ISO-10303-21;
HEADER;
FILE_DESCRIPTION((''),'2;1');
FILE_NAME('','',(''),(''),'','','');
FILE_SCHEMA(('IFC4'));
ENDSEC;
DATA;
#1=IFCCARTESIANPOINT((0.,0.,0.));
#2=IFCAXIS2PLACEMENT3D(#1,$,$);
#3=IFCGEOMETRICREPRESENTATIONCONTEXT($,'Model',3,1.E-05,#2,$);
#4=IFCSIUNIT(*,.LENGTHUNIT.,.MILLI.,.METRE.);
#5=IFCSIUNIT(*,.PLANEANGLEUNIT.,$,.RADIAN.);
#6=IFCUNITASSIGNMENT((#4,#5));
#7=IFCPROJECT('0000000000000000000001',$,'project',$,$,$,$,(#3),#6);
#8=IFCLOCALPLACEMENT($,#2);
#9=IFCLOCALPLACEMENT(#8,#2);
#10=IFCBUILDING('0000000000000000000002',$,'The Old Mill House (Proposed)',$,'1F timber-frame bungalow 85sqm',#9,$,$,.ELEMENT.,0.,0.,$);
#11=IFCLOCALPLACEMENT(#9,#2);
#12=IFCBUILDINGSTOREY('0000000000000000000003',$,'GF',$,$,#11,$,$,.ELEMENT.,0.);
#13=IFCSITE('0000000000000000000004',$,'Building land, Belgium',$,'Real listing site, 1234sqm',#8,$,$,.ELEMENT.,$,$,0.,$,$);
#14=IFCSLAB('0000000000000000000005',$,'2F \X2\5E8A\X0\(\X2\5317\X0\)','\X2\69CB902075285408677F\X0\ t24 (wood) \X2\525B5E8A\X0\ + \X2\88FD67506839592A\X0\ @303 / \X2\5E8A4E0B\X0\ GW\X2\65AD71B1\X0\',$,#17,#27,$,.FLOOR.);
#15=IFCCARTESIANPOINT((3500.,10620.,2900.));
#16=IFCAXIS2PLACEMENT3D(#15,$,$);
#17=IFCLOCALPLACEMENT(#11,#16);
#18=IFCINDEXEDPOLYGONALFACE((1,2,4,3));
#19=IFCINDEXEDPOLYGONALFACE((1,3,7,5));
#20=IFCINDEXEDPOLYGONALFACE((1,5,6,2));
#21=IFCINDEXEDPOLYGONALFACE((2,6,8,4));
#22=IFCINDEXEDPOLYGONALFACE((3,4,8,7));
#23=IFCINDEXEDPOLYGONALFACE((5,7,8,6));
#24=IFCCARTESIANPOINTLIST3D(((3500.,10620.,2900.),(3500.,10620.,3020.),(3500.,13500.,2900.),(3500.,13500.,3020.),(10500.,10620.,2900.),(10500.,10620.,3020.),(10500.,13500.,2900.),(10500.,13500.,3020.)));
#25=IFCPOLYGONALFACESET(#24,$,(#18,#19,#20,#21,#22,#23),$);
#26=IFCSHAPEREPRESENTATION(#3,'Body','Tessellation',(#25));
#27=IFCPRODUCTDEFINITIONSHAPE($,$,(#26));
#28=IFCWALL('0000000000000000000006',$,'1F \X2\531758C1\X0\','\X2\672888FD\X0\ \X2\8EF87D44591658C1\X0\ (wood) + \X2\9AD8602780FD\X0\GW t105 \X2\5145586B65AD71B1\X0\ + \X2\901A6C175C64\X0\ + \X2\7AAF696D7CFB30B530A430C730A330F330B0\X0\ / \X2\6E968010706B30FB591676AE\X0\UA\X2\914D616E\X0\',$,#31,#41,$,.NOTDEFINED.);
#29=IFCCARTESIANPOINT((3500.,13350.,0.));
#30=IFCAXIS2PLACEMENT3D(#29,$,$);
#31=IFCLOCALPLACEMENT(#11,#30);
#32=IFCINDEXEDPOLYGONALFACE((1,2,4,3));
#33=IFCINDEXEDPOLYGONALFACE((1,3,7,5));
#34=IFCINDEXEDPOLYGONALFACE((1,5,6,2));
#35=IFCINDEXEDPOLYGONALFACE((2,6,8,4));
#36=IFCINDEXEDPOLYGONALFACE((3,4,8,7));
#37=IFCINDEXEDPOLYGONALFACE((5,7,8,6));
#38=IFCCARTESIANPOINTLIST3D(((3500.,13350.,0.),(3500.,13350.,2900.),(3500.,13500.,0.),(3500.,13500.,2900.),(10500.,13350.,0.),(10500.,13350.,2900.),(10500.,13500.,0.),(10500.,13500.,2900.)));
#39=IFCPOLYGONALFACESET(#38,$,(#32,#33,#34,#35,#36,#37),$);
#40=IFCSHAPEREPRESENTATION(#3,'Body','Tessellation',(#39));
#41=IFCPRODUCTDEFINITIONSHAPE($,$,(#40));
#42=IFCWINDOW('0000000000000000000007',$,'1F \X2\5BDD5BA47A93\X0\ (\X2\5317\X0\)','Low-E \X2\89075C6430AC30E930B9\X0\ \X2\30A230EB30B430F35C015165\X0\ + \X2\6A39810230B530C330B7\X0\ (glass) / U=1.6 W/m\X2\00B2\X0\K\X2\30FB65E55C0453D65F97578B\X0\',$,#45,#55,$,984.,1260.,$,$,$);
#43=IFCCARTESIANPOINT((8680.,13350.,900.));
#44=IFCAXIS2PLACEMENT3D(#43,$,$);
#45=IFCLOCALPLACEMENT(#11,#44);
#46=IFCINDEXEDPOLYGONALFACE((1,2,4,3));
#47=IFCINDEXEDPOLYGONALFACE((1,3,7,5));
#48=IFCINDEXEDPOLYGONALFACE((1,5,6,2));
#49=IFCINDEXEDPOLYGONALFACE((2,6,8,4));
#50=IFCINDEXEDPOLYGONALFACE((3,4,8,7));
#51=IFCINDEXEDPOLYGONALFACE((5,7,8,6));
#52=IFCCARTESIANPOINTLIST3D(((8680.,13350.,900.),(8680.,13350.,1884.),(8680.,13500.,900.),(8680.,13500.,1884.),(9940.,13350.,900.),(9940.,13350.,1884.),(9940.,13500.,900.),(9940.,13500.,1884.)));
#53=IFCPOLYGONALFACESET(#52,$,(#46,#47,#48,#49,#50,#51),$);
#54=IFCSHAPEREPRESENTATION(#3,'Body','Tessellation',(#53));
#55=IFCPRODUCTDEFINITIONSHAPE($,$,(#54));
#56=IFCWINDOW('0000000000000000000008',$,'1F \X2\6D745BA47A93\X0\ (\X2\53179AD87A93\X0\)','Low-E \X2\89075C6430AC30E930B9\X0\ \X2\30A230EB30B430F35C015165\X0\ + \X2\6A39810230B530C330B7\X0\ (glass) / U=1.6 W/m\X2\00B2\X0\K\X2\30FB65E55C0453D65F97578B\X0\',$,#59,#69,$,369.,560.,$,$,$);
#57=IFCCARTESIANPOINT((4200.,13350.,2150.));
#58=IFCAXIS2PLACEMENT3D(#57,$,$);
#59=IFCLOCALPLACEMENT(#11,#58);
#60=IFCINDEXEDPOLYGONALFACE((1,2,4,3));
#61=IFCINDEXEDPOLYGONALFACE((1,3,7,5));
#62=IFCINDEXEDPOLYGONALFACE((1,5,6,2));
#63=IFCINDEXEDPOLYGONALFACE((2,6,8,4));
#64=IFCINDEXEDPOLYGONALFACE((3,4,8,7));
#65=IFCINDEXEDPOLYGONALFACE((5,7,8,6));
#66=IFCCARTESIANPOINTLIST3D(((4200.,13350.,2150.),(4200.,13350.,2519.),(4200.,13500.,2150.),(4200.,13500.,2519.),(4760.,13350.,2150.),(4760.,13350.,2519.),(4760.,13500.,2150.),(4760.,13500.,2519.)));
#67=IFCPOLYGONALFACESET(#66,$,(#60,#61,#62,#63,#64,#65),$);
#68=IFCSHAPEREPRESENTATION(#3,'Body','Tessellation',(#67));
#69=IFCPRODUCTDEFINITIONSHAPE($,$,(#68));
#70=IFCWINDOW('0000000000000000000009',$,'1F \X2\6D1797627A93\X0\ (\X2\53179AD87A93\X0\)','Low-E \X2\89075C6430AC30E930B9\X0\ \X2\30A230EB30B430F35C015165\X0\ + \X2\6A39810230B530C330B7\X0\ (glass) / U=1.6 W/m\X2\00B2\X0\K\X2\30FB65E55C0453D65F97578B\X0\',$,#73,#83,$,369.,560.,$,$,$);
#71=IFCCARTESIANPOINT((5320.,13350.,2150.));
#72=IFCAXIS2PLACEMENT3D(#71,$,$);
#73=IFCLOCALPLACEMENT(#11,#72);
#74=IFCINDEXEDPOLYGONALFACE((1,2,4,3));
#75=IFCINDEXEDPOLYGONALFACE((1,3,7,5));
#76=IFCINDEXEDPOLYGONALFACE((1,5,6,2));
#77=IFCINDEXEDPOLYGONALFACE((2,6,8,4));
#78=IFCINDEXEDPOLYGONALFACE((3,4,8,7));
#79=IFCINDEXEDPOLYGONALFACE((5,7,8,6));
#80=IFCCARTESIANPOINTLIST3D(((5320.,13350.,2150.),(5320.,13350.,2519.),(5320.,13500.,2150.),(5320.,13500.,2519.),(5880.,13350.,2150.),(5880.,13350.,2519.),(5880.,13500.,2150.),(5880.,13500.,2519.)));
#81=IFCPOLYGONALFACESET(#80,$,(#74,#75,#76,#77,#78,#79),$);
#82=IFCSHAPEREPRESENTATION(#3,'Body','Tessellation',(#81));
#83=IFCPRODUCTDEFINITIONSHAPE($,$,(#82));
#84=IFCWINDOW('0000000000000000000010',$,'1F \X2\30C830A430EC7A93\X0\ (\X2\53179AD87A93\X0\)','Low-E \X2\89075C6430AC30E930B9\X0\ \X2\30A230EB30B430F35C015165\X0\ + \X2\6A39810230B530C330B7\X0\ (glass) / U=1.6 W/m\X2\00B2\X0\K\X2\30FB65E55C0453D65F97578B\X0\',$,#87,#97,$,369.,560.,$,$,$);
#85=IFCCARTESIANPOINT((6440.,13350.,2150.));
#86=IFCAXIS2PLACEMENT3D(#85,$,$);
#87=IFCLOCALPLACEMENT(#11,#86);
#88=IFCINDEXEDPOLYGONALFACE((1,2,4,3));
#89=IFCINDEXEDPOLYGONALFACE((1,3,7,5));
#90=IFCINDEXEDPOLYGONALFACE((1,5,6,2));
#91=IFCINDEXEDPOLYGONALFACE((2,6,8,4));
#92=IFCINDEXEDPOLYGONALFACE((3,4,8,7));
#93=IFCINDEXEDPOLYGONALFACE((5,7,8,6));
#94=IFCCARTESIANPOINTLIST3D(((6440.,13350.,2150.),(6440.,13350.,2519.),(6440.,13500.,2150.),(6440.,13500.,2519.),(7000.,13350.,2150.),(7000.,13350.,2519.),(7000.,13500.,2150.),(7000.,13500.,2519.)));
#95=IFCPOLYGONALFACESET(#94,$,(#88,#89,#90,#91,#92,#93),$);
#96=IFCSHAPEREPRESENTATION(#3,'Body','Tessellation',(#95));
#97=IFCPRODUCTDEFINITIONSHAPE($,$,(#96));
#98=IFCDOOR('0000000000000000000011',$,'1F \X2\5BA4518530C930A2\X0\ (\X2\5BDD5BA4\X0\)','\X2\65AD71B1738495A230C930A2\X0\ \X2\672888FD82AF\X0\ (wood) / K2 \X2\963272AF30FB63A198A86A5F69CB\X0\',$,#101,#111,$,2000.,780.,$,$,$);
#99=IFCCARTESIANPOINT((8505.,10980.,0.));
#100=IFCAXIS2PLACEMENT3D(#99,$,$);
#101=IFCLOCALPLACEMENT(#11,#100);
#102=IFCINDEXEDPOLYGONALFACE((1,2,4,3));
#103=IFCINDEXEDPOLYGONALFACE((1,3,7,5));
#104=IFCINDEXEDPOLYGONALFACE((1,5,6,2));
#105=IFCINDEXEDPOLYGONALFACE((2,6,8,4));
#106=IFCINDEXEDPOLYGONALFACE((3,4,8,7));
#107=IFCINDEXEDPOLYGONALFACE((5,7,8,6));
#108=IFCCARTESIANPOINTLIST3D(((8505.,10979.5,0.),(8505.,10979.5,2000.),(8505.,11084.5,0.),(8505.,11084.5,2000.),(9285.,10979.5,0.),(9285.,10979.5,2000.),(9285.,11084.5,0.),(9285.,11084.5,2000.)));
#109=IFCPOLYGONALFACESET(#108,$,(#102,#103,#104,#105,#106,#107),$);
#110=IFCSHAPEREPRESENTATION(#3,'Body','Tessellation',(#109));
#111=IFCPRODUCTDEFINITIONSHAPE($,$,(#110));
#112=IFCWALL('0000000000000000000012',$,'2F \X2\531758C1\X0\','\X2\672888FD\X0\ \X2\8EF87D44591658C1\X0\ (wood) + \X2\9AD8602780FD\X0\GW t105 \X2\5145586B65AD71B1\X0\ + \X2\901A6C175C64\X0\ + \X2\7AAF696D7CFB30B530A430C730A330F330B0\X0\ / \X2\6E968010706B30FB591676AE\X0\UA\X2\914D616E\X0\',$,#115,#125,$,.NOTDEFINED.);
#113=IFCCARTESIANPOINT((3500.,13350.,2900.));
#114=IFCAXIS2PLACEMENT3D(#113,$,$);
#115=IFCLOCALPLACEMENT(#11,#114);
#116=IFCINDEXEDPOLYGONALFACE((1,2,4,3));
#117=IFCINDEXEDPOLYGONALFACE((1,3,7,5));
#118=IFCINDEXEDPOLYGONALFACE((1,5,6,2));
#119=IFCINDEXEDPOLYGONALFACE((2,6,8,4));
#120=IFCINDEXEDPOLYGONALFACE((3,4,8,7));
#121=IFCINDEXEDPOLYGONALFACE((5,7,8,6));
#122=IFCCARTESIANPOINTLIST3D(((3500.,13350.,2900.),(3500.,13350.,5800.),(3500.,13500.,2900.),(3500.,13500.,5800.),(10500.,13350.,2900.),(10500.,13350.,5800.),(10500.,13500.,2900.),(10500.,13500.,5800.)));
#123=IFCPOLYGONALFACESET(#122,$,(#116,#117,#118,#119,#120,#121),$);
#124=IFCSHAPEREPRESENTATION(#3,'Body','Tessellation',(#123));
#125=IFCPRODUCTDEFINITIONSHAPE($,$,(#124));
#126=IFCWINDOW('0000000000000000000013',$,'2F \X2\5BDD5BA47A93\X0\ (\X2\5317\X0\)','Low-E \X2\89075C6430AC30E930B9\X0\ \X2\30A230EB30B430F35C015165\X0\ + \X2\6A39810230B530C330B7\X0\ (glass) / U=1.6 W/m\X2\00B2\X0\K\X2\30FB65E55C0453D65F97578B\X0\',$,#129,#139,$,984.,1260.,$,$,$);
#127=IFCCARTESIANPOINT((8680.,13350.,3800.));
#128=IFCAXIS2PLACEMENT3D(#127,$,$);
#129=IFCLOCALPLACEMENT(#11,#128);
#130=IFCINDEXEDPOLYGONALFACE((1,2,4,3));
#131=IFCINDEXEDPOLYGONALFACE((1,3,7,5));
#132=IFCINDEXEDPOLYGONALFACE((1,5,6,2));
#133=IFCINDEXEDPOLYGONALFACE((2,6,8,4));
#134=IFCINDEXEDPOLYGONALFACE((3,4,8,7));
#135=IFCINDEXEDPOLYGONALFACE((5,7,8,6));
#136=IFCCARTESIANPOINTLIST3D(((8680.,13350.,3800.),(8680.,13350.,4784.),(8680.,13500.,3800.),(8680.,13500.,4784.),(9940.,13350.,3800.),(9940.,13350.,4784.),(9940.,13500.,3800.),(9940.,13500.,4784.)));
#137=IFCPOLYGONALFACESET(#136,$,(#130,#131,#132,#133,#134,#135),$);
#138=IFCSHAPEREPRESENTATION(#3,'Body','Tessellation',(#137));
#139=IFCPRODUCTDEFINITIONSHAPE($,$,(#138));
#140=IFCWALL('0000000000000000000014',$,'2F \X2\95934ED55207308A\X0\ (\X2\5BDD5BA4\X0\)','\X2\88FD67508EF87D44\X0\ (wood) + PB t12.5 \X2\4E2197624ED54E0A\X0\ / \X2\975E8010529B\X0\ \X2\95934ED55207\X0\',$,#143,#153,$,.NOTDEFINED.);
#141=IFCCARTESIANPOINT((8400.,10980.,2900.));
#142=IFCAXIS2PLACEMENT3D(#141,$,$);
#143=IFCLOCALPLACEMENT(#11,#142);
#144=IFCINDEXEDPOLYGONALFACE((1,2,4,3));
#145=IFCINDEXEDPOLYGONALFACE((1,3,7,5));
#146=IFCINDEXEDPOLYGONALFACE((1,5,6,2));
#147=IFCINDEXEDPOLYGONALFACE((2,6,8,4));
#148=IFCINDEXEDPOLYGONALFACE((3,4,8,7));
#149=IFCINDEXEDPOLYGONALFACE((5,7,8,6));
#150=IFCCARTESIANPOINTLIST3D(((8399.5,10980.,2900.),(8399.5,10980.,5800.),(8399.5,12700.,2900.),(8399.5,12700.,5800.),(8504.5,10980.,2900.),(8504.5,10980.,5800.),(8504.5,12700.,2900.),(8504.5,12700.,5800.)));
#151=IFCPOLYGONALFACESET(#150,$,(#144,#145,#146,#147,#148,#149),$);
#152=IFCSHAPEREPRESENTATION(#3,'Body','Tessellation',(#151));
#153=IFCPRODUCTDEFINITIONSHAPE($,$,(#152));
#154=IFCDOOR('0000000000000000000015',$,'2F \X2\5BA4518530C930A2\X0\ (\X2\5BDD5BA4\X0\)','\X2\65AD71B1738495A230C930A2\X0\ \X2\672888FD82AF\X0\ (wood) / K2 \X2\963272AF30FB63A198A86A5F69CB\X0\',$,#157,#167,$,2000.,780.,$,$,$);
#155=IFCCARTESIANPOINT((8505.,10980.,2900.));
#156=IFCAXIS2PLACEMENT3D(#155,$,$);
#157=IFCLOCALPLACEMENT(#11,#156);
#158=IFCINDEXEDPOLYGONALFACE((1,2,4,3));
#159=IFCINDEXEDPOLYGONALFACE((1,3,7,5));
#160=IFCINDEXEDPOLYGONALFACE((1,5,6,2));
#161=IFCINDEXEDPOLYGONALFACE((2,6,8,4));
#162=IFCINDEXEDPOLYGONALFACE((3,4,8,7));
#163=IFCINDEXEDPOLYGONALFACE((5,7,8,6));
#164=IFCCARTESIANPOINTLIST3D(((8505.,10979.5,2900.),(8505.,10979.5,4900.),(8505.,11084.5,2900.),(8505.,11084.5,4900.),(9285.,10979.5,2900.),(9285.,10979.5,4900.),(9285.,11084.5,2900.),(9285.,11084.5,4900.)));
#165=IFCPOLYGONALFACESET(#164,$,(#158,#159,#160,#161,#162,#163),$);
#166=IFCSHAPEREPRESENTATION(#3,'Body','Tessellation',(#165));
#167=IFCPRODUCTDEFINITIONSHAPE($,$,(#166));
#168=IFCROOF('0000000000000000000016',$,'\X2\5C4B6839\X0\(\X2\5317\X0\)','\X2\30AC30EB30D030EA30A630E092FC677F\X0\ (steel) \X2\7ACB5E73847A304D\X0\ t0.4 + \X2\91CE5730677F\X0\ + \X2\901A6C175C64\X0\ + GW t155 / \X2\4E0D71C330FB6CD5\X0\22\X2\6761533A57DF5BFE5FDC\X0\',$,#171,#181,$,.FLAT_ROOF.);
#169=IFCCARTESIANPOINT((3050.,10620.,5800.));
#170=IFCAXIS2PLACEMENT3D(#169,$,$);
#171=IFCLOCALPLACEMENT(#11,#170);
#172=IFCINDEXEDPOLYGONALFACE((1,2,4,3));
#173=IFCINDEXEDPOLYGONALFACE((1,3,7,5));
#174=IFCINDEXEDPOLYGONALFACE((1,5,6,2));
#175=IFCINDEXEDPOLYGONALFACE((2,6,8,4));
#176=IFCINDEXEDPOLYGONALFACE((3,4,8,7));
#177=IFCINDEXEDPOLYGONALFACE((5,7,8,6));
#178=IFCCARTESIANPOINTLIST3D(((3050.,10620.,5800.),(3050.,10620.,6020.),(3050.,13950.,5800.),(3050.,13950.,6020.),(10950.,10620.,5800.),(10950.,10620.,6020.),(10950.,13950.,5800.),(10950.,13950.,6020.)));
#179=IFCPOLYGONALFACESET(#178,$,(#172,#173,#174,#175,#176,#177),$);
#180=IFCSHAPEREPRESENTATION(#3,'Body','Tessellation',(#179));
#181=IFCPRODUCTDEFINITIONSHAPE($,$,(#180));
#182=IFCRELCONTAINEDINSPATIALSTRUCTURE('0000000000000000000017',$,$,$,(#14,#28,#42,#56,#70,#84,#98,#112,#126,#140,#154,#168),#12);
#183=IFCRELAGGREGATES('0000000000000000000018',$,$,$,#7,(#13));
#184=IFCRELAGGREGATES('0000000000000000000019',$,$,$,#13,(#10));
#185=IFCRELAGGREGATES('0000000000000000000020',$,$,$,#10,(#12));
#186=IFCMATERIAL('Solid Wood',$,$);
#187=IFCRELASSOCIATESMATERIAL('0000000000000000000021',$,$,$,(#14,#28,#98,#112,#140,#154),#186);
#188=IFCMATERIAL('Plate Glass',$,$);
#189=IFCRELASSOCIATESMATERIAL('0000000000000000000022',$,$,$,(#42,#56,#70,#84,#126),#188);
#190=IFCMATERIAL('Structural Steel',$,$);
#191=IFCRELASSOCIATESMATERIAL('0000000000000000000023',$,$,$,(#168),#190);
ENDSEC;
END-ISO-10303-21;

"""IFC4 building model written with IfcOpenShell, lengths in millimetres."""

from ifc_helpers import new_model, si_unit, frame, frame_2d, origin, place, context, project, spatial, rectangle, extrude, material, element, fill, save


model = new_model("IFC4")

# Units and contexts
model_context = context("Model", 3, precision=1e-05, world=origin())
ifc_project = project(units=[si_unit("LENGTHUNIT", "METRE", prefix="MILLI"), si_unit("PLANEANGLEUNIT", "RADIAN")], contexts=[model_context])

# Site, building, storey
site_placement = place(None, origin())
site = spatial("IfcSite", under=ifc_project, at=site_placement, Name="Building land, Belgium", ObjectType="Real listing site, 1234sqm", CompositionType="ELEMENT", RefElevation=0.0)
building_placement = place(site_placement, origin())
building = spatial("IfcBuilding", under=site, at=building_placement, Name="The Old Mill House (Proposed)", ObjectType="1F timber-frame bungalow 85sqm", CompositionType="ELEMENT", ElevationOfRefHeight=0.0, ElevationOfTerrain=0.0)
storey_placement = place(building_placement, origin())
storey = spatial("IfcBuildingStorey", under=building, at=storey_placement, Name="GF", CompositionType="ELEMENT", Elevation=0.0)

# Slab
ifc_material_1 = material(Name="Solid Wood")
slab_placement = place(storey_placement, frame((3500.0, 10620.0, 2900.0)))
element("IfcSlab", 1, at=slab_placement, inside=storey, material=ifc_material_1, Name="2F 床(北)", Description="構造用合板 t24 (wood) 剛床 + 製材根太 @303 / 床下 GW断熱", PredefinedType="FLOOR", context=model_context, shape_type="SweptSolid", body=[
    extrude(rectangle(XDim=7000.0, YDim=2880.0, at=frame_2d((3500.0, 1440.0))), frame((3500.0, 10620.0, 2900.0)), (0.0, 0.0, 1.0), 120.0),
])

# Wall, openings, windows
wall_1_placement = place(storey_placement, frame((3500.0, 13350.0, 0.0)))
wall_1 = element("IfcWall", 2, at=wall_1_placement, inside=storey, material=ifc_material_1, Name="1F 北壁", Description="木製 軸組外壁 (wood) + 高性能GW t105 充填断熱 + 通気層 + 窯業系サイディング / 準耐火・外皮UA配慮", PredefinedType="NOTDEFINED", context=model_context, shape_type="SweptSolid", body=[
    extrude(rectangle(XDim=7000.0, YDim=150.0, at=frame_2d((3500.0, 75.0))), frame((3500.0, 13350.0, 0.0)), (0.0, 0.0, 1.0), 2900.0),
])
opening_1_placement = place(storey_placement, frame((8680.0, 13350.0, 900.0)))
opening_1 = element("IfcOpeningElement", 3, at=opening_1_placement, cuts=wall_1, PredefinedType="NOTDEFINED", context=model_context, shape_type="SweptSolid", body=[
    extrude(rectangle(XDim=1260.0, YDim=150.0, at=frame_2d((630.0, 75.0))), frame((8680.0, 13350.0, 900.0)), (0.0, 0.0, 1.0), 984.0),
])
opening_2_placement = place(storey_placement, frame((4200.0, 13350.0, 2150.0)))
opening_2 = element("IfcOpeningElement", 4, at=opening_2_placement, cuts=wall_1, PredefinedType="NOTDEFINED", context=model_context, shape_type="SweptSolid", body=[
    extrude(rectangle(XDim=560.0, YDim=150.0, at=frame_2d((280.0, 75.0))), frame((4200.0, 13350.0, 2150.0)), (0.0, 0.0, 1.0), 369.0),
])
opening_3_placement = place(storey_placement, frame((5320.0, 13350.0, 2150.0)))
opening_3 = element("IfcOpeningElement", 5, at=opening_3_placement, cuts=wall_1, PredefinedType="NOTDEFINED", context=model_context, shape_type="SweptSolid", body=[
    extrude(rectangle(XDim=560.0, YDim=150.0, at=frame_2d((280.0, 75.0))), frame((5320.0, 13350.0, 2150.0)), (0.0, 0.0, 1.0), 369.0),
])
opening_4_placement = place(storey_placement, frame((6440.0, 13350.0, 2150.0)))
opening_4 = element("IfcOpeningElement", 6, at=opening_4_placement, cuts=wall_1, PredefinedType="NOTDEFINED", context=model_context, shape_type="SweptSolid", body=[
    extrude(rectangle(XDim=560.0, YDim=150.0, at=frame_2d((280.0, 75.0))), frame((6440.0, 13350.0, 2150.0)), (0.0, 0.0, 1.0), 369.0),
])
ifc_material_2 = material(Name="Plate Glass")
window_1_placement = place(storey_placement, frame((8680.0, 13350.0, 900.0)))
window_1 = element("IfcWindow", 7, at=window_1_placement, inside=storey, material=ifc_material_2, Name="1F 寝室窓 (北)", Description="Low-E 複層ガラス アルゴン封入 + 樹脂サッシ (glass) / U=1.6 W/m²K・日射取得型", OverallHeight=984.0, OverallWidth=1260.0, context=model_context, shape_type="SweptSolid", body=[
    extrude(rectangle(XDim=1260.0, YDim=150.0, at=frame_2d((630.0, 75.0))), frame((8680.0, 13350.0, 900.0)), (0.0, 0.0, 1.0), 984.0),
])
fill(opening_1, window_1)
window_2_placement = place(storey_placement, frame((4200.0, 13350.0, 2150.0)))
window_2 = element("IfcWindow", 8, at=window_2_placement, inside=storey, material=ifc_material_2, Name="1F 浴室窓 (北高窓)", Description="Low-E 複層ガラス アルゴン封入 + 樹脂サッシ (glass) / U=1.6 W/m²K・日射取得型", OverallHeight=369.0, OverallWidth=560.0, context=model_context, shape_type="SweptSolid", body=[
    extrude(rectangle(XDim=560.0, YDim=150.0, at=frame_2d((280.0, 75.0))), frame((4200.0, 13350.0, 2150.0)), (0.0, 0.0, 1.0), 369.0),
])
fill(opening_2, window_2)
window_3_placement = place(storey_placement, frame((5320.0, 13350.0, 2150.0)))
window_3 = element("IfcWindow", 9, at=window_3_placement, inside=storey, material=ifc_material_2, Name="1F 洗面窓 (北高窓)", Description="Low-E 複層ガラス アルゴン封入 + 樹脂サッシ (glass) / U=1.6 W/m²K・日射取得型", OverallHeight=369.0, OverallWidth=560.0, context=model_context, shape_type="SweptSolid", body=[
    extrude(rectangle(XDim=560.0, YDim=150.0, at=frame_2d((280.0, 75.0))), frame((5320.0, 13350.0, 2150.0)), (0.0, 0.0, 1.0), 369.0),
])
fill(opening_3, window_3)
window_4_placement = place(storey_placement, frame((6440.0, 13350.0, 2150.0)))
window_4 = element("IfcWindow", 10, at=window_4_placement, inside=storey, material=ifc_material_2, Name="1F トイレ窓 (北高窓)", Description="Low-E 複層ガラス アルゴン封入 + 樹脂サッシ (glass) / U=1.6 W/m²K・日射取得型", OverallHeight=369.0, OverallWidth=560.0, context=model_context, shape_type="SweptSolid", body=[
    extrude(rectangle(XDim=560.0, YDim=150.0, at=frame_2d((280.0, 75.0))), frame((6440.0, 13350.0, 2150.0)), (0.0, 0.0, 1.0), 369.0),
])
fill(opening_4, window_4)

# Door
door_1_placement = place(storey_placement, frame((8505.0, 10980.0, 0.0)))
element("IfcDoor", 11, at=door_1_placement, inside=storey, material=ifc_material_1, Name="1F 室内ドア (寝室)", Description="断熱玄関ドア 木製芯 (wood) / K2 防犯・採風機構", OverallHeight=2000.0, OverallWidth=780.0, context=model_context, shape_type="SweptSolid", body=[
    extrude(rectangle(XDim=780.0, YDim=105.0, at=frame_2d((390.0, 52.0))), frame((8505.0, 10980.0, 0.0)), (0.0, 0.0, 1.0), 2000.0),
])

# Wall, opening, window
wall_2_placement = place(storey_placement, frame((3500.0, 13350.0, 2900.0)))
wall_2 = element("IfcWall", 12, at=wall_2_placement, inside=storey, material=ifc_material_1, Name="2F 北壁", Description="木製 軸組外壁 (wood) + 高性能GW t105 充填断熱 + 通気層 + 窯業系サイディング / 準耐火・外皮UA配慮", PredefinedType="NOTDEFINED", context=model_context, shape_type="SweptSolid", body=[
    extrude(rectangle(XDim=7000.0, YDim=150.0, at=frame_2d((3500.0, 75.0))), frame((3500.0, 13350.0, 2900.0)), (0.0, 0.0, 1.0), 2900.0),
])
opening_5_placement = place(storey_placement, frame((8680.0, 13350.0, 3800.0)))
opening_5 = element("IfcOpeningElement", 13, at=opening_5_placement, cuts=wall_2, PredefinedType="NOTDEFINED", context=model_context, shape_type="SweptSolid", body=[
    extrude(rectangle(XDim=1260.0, YDim=150.0, at=frame_2d((630.0, 75.0))), frame((8680.0, 13350.0, 3800.0)), (0.0, 0.0, 1.0), 984.0),
])
window_5_placement = place(storey_placement, frame((8680.0, 13350.0, 3800.0)))
window_5 = element("IfcWindow", 14, at=window_5_placement, inside=storey, material=ifc_material_2, Name="2F 寝室窓 (北)", Description="Low-E 複層ガラス アルゴン封入 + 樹脂サッシ (glass) / U=1.6 W/m²K・日射取得型", OverallHeight=984.0, OverallWidth=1260.0, context=model_context, shape_type="SweptSolid", body=[
    extrude(rectangle(XDim=1260.0, YDim=150.0, at=frame_2d((630.0, 75.0))), frame((8680.0, 13350.0, 3800.0)), (0.0, 0.0, 1.0), 984.0),
])
fill(opening_5, window_5)

# Wall
wall_3_placement = place(storey_placement, frame((8400.0, 10980.0, 2900.0)))
element("IfcWall", 15, at=wall_3_placement, inside=storey, material=ifc_material_1, Name="2F 間仕切り (寝室)", Description="製材軸組 (wood) + PB t12.5 両面仕上 / 非耐力 間仕切", PredefinedType="NOTDEFINED", context=model_context, shape_type="SweptSolid", body=[
    extrude(rectangle(XDim=105.0, YDim=1720.0, at=frame_2d((52.0, 860.0))), frame((8400.0, 10980.0, 2900.0)), (0.0, 0.0, 1.0), 2900.0),
])

# Door
door_2_placement = place(storey_placement, frame((8505.0, 10980.0, 2900.0)))
element("IfcDoor", 16, at=door_2_placement, inside=storey, material=ifc_material_1, Name="2F 室内ドア (寝室)", Description="断熱玄関ドア 木製芯 (wood) / K2 防犯・採風機構", OverallHeight=2000.0, OverallWidth=780.0, context=model_context, shape_type="SweptSolid", body=[
    extrude(rectangle(XDim=780.0, YDim=105.0, at=frame_2d((390.0, 52.0))), frame((8505.0, 10980.0, 2900.0)), (0.0, 0.0, 1.0), 2000.0),
])

# Roof
ifc_material_3 = material(Name="Structural Steel")
roof_placement = place(storey_placement, frame((3050.0, 10620.0, 5800.0)))
element("IfcRoof", 17, at=roof_placement, inside=storey, material=ifc_material_3, Name="屋根(北)", Description="ガルバリウム鋼板 (steel) 立平葺き t0.4 + 野地板 + 通気層 + GW t155 / 不燃・法22条区域対応", PredefinedType="FLAT_ROOF", context=model_context, shape_type="SweptSolid", body=[
    extrude(rectangle(XDim=7900.0, YDim=3330.0, at=frame_2d((3950.0, 1665.0))), frame((3050.0, 10620.0, 5800.0)), (0.0, 0.0, 1.0), 220.0),
])

save(model, "model.ifc")
